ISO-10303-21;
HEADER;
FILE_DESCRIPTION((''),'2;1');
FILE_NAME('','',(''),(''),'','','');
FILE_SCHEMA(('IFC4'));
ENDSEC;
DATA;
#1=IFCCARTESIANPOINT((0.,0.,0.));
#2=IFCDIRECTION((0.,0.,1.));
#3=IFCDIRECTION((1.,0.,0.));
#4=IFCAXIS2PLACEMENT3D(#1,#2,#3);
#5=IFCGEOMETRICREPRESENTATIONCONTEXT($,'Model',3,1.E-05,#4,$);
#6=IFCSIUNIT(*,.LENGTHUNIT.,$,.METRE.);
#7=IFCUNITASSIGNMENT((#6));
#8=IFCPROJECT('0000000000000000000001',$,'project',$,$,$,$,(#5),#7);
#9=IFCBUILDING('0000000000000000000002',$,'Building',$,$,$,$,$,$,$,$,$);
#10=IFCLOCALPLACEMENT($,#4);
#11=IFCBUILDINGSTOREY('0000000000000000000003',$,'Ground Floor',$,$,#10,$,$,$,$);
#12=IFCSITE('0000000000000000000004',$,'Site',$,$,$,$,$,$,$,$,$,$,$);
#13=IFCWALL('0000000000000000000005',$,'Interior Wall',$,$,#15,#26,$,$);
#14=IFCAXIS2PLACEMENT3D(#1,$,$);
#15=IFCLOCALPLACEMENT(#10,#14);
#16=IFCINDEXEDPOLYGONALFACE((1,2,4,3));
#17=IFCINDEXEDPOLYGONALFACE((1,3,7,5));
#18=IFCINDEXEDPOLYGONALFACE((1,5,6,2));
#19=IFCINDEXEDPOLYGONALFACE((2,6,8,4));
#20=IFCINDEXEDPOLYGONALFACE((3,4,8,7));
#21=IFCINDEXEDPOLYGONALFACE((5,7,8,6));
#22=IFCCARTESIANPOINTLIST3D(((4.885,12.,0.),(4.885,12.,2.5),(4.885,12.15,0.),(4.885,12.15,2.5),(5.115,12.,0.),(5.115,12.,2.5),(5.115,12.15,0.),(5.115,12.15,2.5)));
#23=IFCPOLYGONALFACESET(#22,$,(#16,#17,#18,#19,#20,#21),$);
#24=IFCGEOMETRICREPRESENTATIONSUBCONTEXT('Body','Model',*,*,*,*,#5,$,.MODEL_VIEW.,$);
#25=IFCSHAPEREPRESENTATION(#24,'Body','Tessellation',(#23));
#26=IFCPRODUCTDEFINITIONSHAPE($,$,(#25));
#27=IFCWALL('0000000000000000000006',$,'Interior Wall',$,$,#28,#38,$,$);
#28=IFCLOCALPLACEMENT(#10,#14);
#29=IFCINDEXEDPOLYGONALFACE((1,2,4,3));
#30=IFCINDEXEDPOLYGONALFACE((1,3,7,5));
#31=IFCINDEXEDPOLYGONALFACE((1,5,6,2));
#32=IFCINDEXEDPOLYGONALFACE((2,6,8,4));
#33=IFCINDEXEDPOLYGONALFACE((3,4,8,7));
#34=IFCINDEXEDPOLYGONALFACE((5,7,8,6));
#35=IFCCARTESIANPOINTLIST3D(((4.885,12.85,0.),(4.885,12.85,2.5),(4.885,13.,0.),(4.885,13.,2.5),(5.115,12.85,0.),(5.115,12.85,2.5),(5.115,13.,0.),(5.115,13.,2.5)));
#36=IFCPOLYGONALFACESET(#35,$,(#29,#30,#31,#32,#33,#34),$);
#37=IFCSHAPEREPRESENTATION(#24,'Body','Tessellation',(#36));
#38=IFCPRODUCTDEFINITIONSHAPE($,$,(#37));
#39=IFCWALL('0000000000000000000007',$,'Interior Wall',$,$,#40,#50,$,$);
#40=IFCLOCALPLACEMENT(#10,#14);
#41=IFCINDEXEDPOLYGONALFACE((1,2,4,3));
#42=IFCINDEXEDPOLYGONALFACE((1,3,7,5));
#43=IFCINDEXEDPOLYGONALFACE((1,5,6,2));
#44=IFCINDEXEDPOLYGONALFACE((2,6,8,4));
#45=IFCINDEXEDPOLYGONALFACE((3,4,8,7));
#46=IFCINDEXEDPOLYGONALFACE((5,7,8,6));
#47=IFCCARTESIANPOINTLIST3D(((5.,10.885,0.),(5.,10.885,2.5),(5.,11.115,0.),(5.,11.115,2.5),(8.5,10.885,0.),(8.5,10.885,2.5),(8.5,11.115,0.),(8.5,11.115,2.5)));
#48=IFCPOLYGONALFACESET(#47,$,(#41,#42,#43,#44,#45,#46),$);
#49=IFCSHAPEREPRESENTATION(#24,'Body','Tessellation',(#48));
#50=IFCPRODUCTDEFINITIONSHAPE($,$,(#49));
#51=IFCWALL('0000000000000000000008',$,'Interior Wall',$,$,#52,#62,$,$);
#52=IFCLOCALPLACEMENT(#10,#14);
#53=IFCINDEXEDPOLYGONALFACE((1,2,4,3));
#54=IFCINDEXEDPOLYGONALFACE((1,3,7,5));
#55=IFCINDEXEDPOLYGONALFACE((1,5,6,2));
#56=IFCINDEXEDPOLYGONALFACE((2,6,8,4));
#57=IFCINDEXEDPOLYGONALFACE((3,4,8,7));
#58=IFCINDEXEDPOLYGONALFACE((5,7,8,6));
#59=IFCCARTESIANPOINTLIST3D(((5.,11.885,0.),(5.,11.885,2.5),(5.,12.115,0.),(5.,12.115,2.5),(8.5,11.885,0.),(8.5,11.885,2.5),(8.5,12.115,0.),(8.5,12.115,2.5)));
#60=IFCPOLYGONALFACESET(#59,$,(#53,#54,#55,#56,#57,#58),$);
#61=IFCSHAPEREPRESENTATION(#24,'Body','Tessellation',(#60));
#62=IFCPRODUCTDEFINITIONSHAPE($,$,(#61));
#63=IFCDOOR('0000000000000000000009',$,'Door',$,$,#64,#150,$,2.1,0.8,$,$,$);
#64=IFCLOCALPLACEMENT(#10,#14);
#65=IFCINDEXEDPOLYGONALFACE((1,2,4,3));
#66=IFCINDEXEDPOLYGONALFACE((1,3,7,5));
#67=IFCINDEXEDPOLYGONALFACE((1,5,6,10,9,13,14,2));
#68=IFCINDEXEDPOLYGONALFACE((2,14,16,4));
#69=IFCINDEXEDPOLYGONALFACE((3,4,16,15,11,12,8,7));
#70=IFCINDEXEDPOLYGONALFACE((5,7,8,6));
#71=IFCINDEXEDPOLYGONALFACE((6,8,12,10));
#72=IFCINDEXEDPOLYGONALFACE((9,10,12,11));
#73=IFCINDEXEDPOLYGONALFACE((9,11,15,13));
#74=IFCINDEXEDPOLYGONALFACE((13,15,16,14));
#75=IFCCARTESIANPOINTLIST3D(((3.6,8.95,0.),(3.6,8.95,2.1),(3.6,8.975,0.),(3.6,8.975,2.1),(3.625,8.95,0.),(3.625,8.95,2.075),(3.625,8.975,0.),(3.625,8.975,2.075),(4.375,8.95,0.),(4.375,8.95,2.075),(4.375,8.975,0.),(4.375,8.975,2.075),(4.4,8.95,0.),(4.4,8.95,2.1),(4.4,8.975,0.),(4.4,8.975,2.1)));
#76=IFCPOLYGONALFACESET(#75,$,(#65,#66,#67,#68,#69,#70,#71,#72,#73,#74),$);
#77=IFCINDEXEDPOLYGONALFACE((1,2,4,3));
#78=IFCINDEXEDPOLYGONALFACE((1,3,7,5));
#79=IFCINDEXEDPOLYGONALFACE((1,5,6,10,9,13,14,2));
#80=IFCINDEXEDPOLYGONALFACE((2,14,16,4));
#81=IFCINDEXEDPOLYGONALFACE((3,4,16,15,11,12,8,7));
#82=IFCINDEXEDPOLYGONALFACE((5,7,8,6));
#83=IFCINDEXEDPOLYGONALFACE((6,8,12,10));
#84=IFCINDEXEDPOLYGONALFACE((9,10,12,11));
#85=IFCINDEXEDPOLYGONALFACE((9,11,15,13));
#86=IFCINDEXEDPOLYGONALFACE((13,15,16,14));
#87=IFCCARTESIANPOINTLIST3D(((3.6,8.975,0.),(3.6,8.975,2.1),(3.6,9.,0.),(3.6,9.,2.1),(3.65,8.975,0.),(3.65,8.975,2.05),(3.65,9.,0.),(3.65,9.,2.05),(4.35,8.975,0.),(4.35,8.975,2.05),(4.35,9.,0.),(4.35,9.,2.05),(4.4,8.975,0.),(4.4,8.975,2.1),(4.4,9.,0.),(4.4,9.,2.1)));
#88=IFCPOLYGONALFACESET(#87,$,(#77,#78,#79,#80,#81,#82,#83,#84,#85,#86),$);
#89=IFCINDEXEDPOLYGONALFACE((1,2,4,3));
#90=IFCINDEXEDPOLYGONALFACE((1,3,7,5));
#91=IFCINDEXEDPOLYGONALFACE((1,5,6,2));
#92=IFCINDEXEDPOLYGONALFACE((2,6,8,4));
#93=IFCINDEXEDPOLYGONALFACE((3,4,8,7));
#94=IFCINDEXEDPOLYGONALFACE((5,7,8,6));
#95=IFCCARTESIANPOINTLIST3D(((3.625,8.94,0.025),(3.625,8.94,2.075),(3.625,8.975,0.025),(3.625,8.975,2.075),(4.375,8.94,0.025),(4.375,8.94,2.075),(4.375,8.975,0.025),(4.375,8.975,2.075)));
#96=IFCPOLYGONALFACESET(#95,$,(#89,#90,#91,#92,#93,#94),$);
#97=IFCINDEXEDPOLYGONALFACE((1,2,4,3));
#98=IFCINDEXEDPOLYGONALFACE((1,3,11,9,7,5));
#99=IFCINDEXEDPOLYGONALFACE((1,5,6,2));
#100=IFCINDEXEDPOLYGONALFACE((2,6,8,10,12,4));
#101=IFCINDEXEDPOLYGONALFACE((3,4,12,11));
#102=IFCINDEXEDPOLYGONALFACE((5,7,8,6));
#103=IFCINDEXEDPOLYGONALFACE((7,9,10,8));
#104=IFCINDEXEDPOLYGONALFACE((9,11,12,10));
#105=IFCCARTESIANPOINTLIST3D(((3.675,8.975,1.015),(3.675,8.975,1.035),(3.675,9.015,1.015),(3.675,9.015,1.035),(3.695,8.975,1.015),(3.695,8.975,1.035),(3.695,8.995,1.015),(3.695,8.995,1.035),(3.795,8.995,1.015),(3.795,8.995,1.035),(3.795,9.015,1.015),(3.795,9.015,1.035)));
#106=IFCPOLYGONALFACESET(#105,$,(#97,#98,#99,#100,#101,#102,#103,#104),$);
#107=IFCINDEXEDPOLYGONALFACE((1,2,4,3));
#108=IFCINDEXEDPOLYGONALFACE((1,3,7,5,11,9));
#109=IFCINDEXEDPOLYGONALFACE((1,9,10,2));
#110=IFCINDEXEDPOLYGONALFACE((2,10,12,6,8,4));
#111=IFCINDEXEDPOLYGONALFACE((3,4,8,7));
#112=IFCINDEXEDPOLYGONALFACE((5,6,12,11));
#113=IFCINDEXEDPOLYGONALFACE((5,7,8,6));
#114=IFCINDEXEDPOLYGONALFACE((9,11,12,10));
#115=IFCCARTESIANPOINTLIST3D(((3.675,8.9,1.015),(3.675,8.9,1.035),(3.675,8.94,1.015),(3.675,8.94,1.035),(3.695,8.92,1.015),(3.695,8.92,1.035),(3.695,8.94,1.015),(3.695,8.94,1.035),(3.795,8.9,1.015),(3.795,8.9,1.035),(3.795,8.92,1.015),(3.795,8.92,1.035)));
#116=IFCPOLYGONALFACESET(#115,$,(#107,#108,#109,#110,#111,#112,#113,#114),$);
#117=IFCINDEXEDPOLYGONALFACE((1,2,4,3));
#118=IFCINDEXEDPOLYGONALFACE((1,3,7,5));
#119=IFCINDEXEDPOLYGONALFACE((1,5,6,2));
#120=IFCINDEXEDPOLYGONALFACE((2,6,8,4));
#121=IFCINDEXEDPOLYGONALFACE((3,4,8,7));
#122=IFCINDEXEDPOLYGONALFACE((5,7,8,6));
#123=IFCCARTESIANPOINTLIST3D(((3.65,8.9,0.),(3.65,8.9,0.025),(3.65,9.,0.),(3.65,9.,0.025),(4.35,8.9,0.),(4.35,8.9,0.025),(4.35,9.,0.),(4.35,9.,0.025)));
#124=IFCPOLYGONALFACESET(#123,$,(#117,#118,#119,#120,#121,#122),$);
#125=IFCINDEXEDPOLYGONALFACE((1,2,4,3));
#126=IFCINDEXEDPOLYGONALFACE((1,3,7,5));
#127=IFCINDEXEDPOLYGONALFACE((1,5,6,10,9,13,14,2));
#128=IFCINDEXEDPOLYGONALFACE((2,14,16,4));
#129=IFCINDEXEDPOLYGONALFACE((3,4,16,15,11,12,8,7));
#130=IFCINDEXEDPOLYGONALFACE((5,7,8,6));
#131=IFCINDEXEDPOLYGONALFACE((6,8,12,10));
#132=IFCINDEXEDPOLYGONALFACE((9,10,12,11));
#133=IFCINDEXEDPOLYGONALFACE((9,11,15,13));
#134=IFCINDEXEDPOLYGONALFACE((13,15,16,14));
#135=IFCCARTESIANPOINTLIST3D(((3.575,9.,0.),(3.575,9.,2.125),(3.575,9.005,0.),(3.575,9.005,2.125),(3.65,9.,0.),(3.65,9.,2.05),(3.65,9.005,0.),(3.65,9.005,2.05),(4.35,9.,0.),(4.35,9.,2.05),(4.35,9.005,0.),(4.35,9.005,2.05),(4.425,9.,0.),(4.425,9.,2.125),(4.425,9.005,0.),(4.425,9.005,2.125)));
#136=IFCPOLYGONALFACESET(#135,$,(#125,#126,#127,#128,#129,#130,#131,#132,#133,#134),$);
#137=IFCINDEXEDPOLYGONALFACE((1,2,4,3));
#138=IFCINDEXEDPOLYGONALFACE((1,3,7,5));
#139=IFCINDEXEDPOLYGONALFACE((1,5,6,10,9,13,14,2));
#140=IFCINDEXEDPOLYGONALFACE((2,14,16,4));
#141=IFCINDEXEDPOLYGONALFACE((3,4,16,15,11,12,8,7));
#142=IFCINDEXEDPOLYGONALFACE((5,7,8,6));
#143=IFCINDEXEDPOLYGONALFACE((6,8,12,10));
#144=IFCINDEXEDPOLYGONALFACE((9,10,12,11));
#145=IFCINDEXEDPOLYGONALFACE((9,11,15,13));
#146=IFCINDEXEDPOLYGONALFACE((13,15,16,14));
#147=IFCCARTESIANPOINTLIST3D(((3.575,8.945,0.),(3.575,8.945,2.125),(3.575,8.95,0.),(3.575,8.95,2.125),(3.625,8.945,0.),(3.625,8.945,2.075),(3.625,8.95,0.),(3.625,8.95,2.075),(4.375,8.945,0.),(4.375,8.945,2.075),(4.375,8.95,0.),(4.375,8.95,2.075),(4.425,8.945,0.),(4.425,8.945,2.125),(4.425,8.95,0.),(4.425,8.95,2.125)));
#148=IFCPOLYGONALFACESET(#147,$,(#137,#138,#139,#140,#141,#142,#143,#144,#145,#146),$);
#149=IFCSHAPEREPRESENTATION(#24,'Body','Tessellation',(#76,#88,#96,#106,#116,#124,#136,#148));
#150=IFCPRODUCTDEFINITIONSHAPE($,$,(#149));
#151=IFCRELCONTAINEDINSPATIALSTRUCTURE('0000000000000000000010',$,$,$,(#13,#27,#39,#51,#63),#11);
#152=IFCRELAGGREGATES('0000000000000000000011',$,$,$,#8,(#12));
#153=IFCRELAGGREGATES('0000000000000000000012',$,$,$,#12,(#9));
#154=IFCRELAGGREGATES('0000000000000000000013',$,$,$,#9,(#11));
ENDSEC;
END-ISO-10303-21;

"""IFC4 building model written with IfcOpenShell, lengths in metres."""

from ifc_helpers import new_model, si_unit, frame, origin_with_axes, place, context, subcontext, project, spatial, line, indexed_curve, outline, extrude, element, save


model = new_model("IFC4")

# Units and contexts
model_context = context("Model", 3, precision=1e-05, world=origin_with_axes())
body_context = subcontext(model_context, "Body", "Model", "MODEL_VIEW")
ifc_project = project(units=[si_unit("LENGTHUNIT", "METRE")], contexts=[model_context])

# Site, building, storey
site = spatial("IfcSite", under=ifc_project, Name="Site")
building = spatial("IfcBuilding", under=site, Name="Building")
storey_placement = place(None, origin_with_axes())
storey = spatial("IfcBuildingStorey", under=building, at=storey_placement, Name="Ground Floor")

# Walls
for number, where, z_axis, x_axis, name in (
    (1, (5.0, 12.0, 0.0), (0.0, 0.0, 1.0), (0.0, 1.0, 0.0), "Interior Wall"),
    (2, (5.0, 12.85, 0.0), (0.0, 0.0, 1.0), (0.0, 1.0, 0.0), "Interior Wall"),
):
    element("IfcWall", number, at=place(storey_placement, frame(where, z_axis=z_axis, x_axis=x_axis)), inside=storey, Name=name, context=body_context, shape_type="SweptSolid", body=[
        extrude(outline(indexed_curve([(0.0, 0.0), (0.0, 0.23), (0.15, 0.23), (0.15, 0.0), (0.0, 0.0)], self_intersect=False)), frame((0.0, -0.115, 0.0), z_axis=(0.0, 0.0, 1.0), x_axis=(1.0, 0.0, 0.0)), (0.0, 0.0, 1.0), 2.5),
    ])
for number, where, z_axis, x_axis, name in (
    (3, (8.5, 11.0, 0.0), (0.0, 0.0, 1.0), (-1.0, 0.0, 0.0), "Interior Wall"),
    (4, (8.5, 12.0, 0.0), (0.0, 0.0, 1.0), (-1.0, 0.0, 0.0), "Interior Wall"),
):
    element("IfcWall", number, at=place(storey_placement, frame(where, z_axis=z_axis, x_axis=x_axis)), inside=storey, Name=name, context=body_context, shape_type="SweptSolid", body=[
        extrude(outline(indexed_curve([(0.0, 0.0), (0.0, 0.23), (3.5, 0.23), (3.5, 0.0), (0.0, 0.0)], self_intersect=False)), frame((0.0, -0.115, 0.0), z_axis=(0.0, 0.0, 1.0), x_axis=(1.0, 0.0, 0.0)), (0.0, 0.0, 1.0), 2.5),
    ])

# Door
door_1_placement = place(storey_placement, frame((4.4, 9.0, 0.0), z_axis=(0.0, 0.0, 1.0), x_axis=(-1.0, 0.0, 0.0)))
element("IfcDoor", 5, at=door_1_placement, inside=storey, Name="Door", OverallHeight=2.1, OverallWidth=0.8, context=body_context, shape_type="SweptSolid", body=[
    extrude(outline(indexed_curve([(0.0, 0.0), (0.0, 2.1), (0.8, 2.1), (0.8, 0.0), (0.775, 0.0), (0.775, 2.075), (0.025, 2.075), (0.025, 0.0)], segments=[line(1, 2, 3, 4, 5, 6, 7, 8, 1)])), frame((0.0, 0.025, 0.0), z_axis=(0.0, -1.0, 0.0), x_axis=(1.0, 0.0, 0.0)), (0.0, 0.0, -1.0), 0.025),
    extrude(outline(indexed_curve([(0.0, 0.0), (0.0, 2.1), (0.8, 2.1), (0.8, 0.0), (0.75, 0.0), (0.75, 2.05), (0.05, 2.05), (0.05, 0.0)], segments=[line(1, 2, 3, 4, 5, 6, 7, 8, 1)])), frame((0.0, 0.0, 0.0), z_axis=(0.0, -1.0, 0.0), x_axis=(1.0, 0.0, 0.0)), (0.0, 0.0, -1.0), 0.025),
    extrude(outline(indexed_curve([(0.0, 0.0), (0.75, 0.0), (0.75, 0.035), (0.0, 0.035)], segments=[line(1, 2, 3, 4, 1)])), frame((0.025, 0.025, 0.025), z_axis=(0.0, 0.0, 1.0), x_axis=(1.0, 0.0, 0.0)), (0.0, 0.0, 1.0), 2.05),
    extrude(outline(indexed_curve([(0.0, 0.0), (0.0, -0.04), (-0.12, -0.04), (-0.12, -0.02), (-0.02, -0.02), (-0.02, 0.0)], segments=[line(1, 2, 3, 4, 5, 6, 1)])), frame((0.725, 0.025, 1.015), z_axis=(0.0, 0.0, 1.0), x_axis=(1.0, 0.0, 0.0)), (0.0, 0.0, 1.0), 0.02),
    extrude(outline(indexed_curve([(0.0, 0.0), (0.0, 0.04), (-0.12, 0.04), (-0.12, 0.02), (-0.02, 0.02), (-0.02, 0.0)], segments=[line(1, 2, 3, 4, 5, 6, 1)])), frame((0.725, 0.06, 1.015), z_axis=(0.0, 0.0, 1.0), x_axis=(1.0, 0.0, 0.0)), (0.0, 0.0, 1.0), 0.02),
    extrude(outline(indexed_curve([(0.0, 0.0), (0.7, 0.0), (0.7, 0.1), (0.0, 0.1)], segments=[line(1, 2, 3, 4, 1)])), frame((0.05, 0.0, 0.0), z_axis=(0.0, 0.0, 1.0), x_axis=(1.0, 0.0, 0.0)), (0.0, 0.0, 1.0), 0.025),
    extrude(outline(indexed_curve([(0.0, 0.0), (0.0, 2.125), (0.85, 2.125), (0.85, 0.0), (0.775, 0.0), (0.775, 2.05), (0.075, 2.05), (0.075, 0.0)], segments=[line(1, 2, 3, 4, 5, 6, 7, 8, 1)])), frame((-0.025, -0.005, 0.0), z_axis=(0.0, -1.0, 0.0), x_axis=(1.0, 0.0, 0.0)), (0.0, 0.0, -1.0), 0.005),
    extrude(outline(indexed_curve([(0.0, 0.0), (0.0, 2.125), (0.85, 2.125), (0.85, 0.0), (0.8, 0.0), (0.8, 2.075), (0.05, 2.075), (0.05, 0.0)], segments=[line(1, 2, 3, 4, 5, 6, 7, 8, 1)])), frame((-0.025, 0.05, 0.0), z_axis=(0.0, -1.0, 0.0), x_axis=(1.0, 0.0, 0.0)), (0.0, 0.0, -1.0), 0.005),
])

save(model, "model.ifc")
